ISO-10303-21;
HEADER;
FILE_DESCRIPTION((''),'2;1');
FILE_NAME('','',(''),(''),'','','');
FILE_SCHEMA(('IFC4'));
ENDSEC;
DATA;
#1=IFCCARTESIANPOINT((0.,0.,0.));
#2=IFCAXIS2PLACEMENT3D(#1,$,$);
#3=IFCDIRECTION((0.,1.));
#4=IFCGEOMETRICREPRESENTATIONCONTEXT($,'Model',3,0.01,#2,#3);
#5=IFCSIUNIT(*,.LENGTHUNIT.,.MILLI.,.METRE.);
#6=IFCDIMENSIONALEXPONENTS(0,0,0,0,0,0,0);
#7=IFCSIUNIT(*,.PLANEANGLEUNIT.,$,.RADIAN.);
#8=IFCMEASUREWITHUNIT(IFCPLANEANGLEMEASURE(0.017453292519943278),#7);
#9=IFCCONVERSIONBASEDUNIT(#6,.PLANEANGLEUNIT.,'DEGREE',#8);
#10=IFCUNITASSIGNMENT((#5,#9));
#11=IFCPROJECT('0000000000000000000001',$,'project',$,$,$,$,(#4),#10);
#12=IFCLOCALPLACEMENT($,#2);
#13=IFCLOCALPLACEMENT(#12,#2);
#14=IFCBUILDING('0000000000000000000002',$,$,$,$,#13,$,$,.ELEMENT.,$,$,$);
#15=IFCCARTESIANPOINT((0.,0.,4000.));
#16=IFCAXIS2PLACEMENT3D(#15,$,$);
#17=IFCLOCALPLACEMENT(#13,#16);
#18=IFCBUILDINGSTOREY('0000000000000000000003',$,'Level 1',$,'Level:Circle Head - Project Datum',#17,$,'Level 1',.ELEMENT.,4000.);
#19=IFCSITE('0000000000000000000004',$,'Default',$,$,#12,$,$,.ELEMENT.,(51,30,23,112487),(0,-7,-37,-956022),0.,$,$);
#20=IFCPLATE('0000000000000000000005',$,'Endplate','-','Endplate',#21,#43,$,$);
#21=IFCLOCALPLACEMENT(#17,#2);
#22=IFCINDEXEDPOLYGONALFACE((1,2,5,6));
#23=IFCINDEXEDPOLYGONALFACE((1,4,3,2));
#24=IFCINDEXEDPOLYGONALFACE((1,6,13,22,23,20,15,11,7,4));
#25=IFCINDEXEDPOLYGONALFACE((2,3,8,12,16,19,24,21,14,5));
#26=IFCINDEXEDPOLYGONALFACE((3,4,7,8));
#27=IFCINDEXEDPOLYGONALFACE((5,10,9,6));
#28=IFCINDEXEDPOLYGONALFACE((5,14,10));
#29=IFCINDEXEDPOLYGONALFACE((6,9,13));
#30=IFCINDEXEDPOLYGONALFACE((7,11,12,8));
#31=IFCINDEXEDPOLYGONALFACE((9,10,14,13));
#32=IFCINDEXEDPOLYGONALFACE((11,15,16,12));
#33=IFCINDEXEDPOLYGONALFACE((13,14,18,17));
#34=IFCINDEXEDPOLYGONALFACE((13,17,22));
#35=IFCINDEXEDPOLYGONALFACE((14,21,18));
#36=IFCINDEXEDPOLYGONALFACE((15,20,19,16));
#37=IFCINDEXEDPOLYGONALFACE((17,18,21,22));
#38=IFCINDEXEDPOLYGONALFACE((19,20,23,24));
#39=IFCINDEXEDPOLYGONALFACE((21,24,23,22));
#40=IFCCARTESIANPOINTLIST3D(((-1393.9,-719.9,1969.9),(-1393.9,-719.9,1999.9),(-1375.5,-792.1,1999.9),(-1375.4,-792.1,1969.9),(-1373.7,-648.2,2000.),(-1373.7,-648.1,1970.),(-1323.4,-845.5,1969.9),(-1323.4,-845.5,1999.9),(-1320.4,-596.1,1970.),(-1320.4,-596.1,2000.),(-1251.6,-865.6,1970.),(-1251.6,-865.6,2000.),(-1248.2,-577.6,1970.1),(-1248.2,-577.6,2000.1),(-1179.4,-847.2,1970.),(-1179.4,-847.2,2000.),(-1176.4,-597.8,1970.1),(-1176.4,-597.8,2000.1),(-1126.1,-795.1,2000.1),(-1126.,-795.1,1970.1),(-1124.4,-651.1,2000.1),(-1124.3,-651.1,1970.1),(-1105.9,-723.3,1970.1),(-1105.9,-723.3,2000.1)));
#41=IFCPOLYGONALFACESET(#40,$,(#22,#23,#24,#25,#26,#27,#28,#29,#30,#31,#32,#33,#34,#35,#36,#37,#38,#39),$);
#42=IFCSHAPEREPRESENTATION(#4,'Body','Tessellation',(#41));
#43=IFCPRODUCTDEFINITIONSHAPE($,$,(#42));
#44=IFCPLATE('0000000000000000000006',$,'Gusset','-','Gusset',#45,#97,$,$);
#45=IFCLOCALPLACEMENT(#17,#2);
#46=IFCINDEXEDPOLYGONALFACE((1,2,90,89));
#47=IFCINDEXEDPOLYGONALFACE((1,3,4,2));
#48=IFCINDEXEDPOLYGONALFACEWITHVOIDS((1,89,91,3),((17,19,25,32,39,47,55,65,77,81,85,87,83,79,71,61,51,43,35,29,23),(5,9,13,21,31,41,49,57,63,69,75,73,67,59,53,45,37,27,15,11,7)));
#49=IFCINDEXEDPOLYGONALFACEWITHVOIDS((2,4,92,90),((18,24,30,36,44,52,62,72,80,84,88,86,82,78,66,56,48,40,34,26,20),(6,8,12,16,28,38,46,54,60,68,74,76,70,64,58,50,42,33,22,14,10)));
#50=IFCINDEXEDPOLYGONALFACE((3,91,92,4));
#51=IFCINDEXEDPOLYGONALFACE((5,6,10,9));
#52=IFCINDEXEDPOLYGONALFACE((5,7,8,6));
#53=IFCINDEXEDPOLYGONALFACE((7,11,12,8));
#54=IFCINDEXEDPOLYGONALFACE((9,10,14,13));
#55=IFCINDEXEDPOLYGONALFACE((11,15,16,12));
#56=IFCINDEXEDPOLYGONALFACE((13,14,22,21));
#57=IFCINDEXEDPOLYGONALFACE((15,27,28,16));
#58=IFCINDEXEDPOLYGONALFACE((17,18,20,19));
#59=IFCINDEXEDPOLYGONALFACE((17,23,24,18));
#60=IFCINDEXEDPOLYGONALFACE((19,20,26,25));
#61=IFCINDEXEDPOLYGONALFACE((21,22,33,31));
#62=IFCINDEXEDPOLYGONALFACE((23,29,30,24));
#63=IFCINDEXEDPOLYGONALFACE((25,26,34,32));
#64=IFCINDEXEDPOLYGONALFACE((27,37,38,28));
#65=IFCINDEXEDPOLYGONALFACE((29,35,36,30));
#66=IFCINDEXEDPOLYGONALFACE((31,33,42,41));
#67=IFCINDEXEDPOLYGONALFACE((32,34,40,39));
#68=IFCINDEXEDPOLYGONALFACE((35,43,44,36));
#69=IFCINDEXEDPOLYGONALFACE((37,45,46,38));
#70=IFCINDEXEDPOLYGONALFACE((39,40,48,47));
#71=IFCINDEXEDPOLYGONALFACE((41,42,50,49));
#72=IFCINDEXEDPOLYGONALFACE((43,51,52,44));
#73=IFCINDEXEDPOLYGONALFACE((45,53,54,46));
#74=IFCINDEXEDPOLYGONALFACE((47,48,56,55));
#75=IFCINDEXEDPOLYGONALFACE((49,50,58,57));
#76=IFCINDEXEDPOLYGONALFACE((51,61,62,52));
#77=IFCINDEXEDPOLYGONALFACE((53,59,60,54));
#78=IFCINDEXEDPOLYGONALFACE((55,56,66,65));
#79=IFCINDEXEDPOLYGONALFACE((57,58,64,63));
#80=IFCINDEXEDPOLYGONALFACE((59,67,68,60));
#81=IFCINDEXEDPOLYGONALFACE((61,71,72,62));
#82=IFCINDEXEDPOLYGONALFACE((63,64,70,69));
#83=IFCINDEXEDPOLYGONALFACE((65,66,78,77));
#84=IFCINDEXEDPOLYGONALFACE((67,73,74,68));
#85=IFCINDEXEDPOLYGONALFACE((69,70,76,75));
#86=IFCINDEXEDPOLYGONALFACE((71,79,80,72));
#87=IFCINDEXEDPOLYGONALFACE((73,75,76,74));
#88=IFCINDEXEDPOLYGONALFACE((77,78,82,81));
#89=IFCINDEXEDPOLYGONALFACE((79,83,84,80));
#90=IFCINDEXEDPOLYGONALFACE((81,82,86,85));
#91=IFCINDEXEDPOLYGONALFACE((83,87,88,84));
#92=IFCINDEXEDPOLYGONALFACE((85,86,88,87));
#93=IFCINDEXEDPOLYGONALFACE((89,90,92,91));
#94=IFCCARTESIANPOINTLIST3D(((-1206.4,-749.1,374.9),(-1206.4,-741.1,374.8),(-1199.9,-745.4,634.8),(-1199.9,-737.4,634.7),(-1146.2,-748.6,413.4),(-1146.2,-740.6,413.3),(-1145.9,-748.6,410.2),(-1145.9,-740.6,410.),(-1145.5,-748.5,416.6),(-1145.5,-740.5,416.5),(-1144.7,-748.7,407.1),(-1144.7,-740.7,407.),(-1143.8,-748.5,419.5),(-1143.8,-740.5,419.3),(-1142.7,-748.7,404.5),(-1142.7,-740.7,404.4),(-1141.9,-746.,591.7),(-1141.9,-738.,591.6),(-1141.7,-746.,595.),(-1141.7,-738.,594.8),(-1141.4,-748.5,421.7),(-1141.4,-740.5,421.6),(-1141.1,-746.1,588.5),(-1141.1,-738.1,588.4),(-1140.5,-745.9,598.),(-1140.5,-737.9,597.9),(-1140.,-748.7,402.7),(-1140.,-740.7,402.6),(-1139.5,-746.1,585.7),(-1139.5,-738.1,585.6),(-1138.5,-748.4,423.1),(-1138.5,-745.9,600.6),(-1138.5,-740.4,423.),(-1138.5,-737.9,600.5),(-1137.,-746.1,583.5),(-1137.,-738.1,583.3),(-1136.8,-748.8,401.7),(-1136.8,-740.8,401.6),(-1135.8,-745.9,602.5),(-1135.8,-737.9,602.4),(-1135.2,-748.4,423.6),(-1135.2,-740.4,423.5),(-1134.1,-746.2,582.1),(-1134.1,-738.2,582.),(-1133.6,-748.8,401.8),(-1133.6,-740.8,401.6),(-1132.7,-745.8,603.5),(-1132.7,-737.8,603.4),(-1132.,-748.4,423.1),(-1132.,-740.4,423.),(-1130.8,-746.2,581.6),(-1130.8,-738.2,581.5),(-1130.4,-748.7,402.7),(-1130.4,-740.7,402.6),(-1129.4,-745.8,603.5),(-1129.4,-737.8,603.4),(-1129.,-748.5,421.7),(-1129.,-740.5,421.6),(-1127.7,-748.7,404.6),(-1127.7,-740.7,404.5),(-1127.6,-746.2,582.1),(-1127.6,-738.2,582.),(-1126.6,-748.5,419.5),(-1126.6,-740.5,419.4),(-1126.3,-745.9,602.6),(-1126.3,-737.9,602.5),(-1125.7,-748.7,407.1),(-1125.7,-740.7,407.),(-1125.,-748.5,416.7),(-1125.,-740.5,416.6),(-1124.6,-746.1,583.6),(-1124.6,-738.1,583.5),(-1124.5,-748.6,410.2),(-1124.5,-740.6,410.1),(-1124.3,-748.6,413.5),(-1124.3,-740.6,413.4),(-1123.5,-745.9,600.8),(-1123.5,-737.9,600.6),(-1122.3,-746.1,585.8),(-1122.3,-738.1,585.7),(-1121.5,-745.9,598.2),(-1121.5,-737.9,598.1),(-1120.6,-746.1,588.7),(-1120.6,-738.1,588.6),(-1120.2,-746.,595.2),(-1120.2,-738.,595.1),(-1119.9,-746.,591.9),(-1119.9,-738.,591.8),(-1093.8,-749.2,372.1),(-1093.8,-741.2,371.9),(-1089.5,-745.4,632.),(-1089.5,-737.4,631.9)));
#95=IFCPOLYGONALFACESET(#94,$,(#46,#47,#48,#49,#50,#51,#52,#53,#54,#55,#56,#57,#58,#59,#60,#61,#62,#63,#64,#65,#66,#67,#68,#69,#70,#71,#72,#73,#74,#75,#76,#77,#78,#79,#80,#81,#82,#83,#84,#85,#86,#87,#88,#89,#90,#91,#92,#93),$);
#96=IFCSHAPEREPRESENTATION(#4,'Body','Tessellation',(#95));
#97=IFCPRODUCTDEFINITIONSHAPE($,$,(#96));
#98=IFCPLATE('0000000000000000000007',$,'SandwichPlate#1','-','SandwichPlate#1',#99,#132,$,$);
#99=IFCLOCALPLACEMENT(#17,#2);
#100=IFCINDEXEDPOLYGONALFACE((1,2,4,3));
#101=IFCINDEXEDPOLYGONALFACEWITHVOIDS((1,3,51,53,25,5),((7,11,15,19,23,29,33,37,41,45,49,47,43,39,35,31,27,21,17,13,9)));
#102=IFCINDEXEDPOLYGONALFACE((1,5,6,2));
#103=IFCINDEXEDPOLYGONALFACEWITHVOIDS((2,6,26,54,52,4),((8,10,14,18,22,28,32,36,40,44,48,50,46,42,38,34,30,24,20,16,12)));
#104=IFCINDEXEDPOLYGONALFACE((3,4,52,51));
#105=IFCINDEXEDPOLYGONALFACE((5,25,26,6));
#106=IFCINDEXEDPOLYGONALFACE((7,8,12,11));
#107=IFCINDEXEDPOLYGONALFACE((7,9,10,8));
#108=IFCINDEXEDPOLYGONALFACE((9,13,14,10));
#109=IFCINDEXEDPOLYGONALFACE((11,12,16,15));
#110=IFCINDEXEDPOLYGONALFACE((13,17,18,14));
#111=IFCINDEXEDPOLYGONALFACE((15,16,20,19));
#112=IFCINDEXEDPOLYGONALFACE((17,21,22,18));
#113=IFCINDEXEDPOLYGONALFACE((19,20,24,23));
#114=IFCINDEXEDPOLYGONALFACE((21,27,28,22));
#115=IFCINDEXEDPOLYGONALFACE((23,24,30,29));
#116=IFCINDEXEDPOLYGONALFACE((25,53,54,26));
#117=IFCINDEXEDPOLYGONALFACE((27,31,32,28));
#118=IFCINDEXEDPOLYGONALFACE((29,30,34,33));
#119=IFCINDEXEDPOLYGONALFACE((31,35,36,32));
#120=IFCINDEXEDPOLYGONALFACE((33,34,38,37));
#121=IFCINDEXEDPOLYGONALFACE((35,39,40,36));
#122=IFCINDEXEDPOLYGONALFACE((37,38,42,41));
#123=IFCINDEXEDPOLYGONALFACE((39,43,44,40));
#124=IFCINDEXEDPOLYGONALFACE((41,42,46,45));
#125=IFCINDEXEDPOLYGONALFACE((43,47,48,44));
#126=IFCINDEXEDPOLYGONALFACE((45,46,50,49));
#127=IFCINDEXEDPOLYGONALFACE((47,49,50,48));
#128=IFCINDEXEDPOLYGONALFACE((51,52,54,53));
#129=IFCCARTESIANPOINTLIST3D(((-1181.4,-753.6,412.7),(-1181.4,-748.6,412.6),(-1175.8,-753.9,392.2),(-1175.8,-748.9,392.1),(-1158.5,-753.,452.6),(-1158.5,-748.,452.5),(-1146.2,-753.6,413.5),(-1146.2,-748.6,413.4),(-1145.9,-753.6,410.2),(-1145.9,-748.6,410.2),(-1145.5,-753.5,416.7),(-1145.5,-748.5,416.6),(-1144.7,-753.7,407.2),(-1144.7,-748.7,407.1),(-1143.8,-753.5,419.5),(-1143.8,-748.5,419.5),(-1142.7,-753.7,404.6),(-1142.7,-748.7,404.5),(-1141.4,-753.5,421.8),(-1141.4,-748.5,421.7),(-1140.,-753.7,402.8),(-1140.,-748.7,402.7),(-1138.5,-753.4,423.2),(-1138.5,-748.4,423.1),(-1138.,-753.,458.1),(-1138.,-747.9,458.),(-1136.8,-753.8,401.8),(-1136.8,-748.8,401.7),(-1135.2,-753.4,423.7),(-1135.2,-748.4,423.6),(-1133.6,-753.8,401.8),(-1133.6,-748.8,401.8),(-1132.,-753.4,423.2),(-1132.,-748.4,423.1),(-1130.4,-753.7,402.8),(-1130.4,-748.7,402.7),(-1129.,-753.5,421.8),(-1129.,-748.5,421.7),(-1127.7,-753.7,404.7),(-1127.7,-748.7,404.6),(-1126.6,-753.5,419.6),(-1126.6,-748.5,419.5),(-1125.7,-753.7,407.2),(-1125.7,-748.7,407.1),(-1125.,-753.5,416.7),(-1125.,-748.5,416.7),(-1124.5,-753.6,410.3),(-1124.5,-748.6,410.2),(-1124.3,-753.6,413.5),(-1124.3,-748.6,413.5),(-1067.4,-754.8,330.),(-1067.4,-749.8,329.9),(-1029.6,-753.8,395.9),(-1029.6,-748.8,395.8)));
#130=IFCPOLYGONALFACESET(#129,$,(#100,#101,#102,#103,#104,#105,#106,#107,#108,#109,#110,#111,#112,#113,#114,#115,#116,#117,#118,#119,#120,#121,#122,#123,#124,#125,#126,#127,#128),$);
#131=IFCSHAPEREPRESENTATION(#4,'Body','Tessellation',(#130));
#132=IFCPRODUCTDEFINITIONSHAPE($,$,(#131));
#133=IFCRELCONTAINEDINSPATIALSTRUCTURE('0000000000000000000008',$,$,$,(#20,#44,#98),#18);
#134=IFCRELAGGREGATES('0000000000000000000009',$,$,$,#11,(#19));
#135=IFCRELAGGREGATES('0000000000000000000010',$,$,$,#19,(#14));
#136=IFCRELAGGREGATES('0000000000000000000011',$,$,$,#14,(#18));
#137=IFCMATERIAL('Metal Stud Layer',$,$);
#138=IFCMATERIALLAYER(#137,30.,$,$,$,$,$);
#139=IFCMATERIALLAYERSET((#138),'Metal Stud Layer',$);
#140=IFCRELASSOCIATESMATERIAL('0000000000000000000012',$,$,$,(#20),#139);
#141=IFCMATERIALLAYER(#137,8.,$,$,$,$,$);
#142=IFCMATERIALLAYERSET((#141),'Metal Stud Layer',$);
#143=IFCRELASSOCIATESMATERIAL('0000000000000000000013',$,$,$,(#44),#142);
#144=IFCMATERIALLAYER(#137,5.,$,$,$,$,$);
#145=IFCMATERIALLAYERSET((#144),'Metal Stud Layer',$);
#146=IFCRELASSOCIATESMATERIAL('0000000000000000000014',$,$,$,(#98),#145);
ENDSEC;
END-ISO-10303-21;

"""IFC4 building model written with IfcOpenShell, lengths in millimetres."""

from ifc_helpers import new_model, entity, si_unit, converted_unit, point, direction, frame, frame_2d, origin, origin_with_axes, origin_2d_with_axis, place, context, project, spatial, polyline, circle_curve, line_curve, trimmed, segment, composite_curve, circle, outline, extrude, material, layer, layer_set, element, save


model = new_model("IFC4")

# Units and contexts
model_context = context("Model", 3, precision=0.01, world=origin(), true_north=direction((0.0, 1.0)))
ifc_project = project(units=[si_unit("LENGTHUNIT", "METRE", prefix="MILLI"), converted_unit("PLANEANGLEUNIT", "DEGREE", entity("IfcPlaneAngleMeasure", 0.017453292519943278), si_unit("PLANEANGLEUNIT", "RADIAN"), dimensions=[0, 0, 0, 0, 0, 0, 0])], contexts=[model_context])

# Site, building, storey
site_placement = place(None, origin())
site = spatial("IfcSite", under=ifc_project, at=site_placement, Name="Default", CompositionType="ELEMENT", RefLatitude=(51, 30, 23, 112487), RefLongitude=(0, -7, -37, -956022), RefElevation=0.0)
building_placement = place(site_placement, origin())
building = spatial("IfcBuilding", under=site, at=building_placement, CompositionType="ELEMENT")
storey_placement = place(building_placement, frame((0.0, 0.0, 4000.0)))
storey = spatial("IfcBuildingStorey", under=building, at=storey_placement, Name="Level 1", ObjectType="Level:Circle Head - Project Datum", LongName="Level 1", CompositionType="ELEMENT", Elevation=4000.0)

# Plates, openings
ifc_material_1 = material(Name="Metal Stud Layer")
ifc_layer_1 = layer(ifc_material_1, 30.0)
ifc_layer_set_1 = layer_set([ifc_layer_1], Name="Metal Stud Layer")
plate_1_placement = place(storey_placement, frame((-1179.4, -847.2, 1970.0), z_axis=(-0.000702, -0.000406, 1.0), x_axis=(0.871905, 0.489674, 0.000811)))
plate_1 = element("IfcPlate", 1, at=plate_1_placement, inside=storey, material=ifc_layer_set_1, Name="Endplate", Description="-", ObjectType="Endplate", context=model_context, shape_type="SweptSolid", body=[
    extrude(outline(polyline([(144.0, 0.0), (144.0, 288.0), (-144.0, 288.0), (-144.0, 0.0), (144.0, 0.0)])), origin_with_axes(), (0.0, 0.0, 1.0), 30.0),
])
opening_1_placement = place(plate_1_placement, frame((0.0, 0.0, 0.0), z_axis=(0.0, 0.0, 1.0), x_axis=(1.0, 0.0, 0.0)))
element("IfcOpeningElement", 2, at=opening_1_placement, cuts=plate_1, ObjectType="Opening", context=model_context, shape_type="SweptSolid", body=[
    extrude(outline(composite_curve([segment(trimmed(line_curve((144.0, 0.0), (0.0, 1.0), 144.0), [point((144.0, 0.0))], [point((144.0, 144.0))], True, "CARTESIAN"), True, "CONTINUOUS"), segment(trimmed(circle_curve(frame_2d((0.0, 144.0), x_axis=(-1.0, 0.0)), 144.0), [point((144.0, 144.0))], [point((0.0, 0.0))], False, "CARTESIAN"), True, "CONTINUOUS"), segment(trimmed(line_curve((0.0, 0.0), (1.0, 0.0), 144.0), [point((0.0, 0.0))], [point((144.0, 0.0))], True, "CARTESIAN"), True, "CONTINUOUS")], self_intersect="UNKNOWN")), origin(), (0.0, 0.0, 1.0), 30.0),
])
opening_2_placement = place(plate_1_placement, frame((0.0, 0.0, 0.0), z_axis=(0.0, 0.0, 1.0), x_axis=(1.0, 0.0, 0.0)))
element("IfcOpeningElement", 3, at=opening_2_placement, cuts=plate_1, ObjectType="Opening", context=model_context, shape_type="SweptSolid", body=[
    extrude(outline(composite_curve([segment(trimmed(line_curve((144.0, 288.0), (-1.0, 0.0), 144.0), [point((144.0, 288.0))], [point((0.0, 288.0))], True, "CARTESIAN"), True, "CONTINUOUS"), segment(trimmed(circle_curve(frame_2d((0.0, 144.0), x_axis=(-1.0, 0.0)), 144.0), [point((0.0, 288.0))], [point((144.0, 144.0))], False, "CARTESIAN"), True, "CONTINUOUS"), segment(trimmed(line_curve((144.0, 144.0), (0.0, 1.0), 144.0), [point((144.0, 144.0))], [point((144.0, 288.0))], True, "CARTESIAN"), True, "CONTINUOUS")], self_intersect="UNKNOWN")), origin(), (0.0, 0.0, 1.0), 30.0),
])
opening_3_placement = place(plate_1_placement, frame((0.0, 0.0, 0.0), z_axis=(0.0, 0.0, 1.0), x_axis=(1.0, 0.0, 0.0)))
element("IfcOpeningElement", 4, at=opening_3_placement, cuts=plate_1, ObjectType="Opening", context=model_context, shape_type="SweptSolid", body=[
    extrude(outline(composite_curve([segment(trimmed(line_curve((-144.0, 288.0), (0.0, -1.0), 144.0), [point((-144.0, 288.0))], [point((-144.0, 144.0))], True, "CARTESIAN"), True, "CONTINUOUS"), segment(trimmed(circle_curve(frame_2d((0.0, 144.0), x_axis=(-1.0, 0.0)), 144.0), [point((-144.0, 144.0))], [point((0.0, 288.0))], False, "CARTESIAN"), True, "CONTINUOUS"), segment(trimmed(line_curve((0.0, 288.0), (-1.0, 0.0), 144.0), [point((0.0, 288.0))], [point((-144.0, 288.0))], True, "CARTESIAN"), True, "CONTINUOUS")], self_intersect="UNKNOWN")), origin(), (0.0, 0.0, 1.0), 30.0),
])
opening_4_placement = place(plate_1_placement, frame((0.0, 0.0, 0.0), z_axis=(0.0, 0.0, 1.0), x_axis=(1.0, 0.0, 0.0)))
element("IfcOpeningElement", 5, at=opening_4_placement, cuts=plate_1, ObjectType="Opening", context=model_context, shape_type="SweptSolid", body=[
    extrude(outline(composite_curve([segment(trimmed(line_curve((-144.0, 0.0), (1.0, 0.0), 144.0), [point((-144.0, 0.0))], [point((0.0, 0.0))], True, "CARTESIAN"), True, "CONTINUOUS"), segment(trimmed(circle_curve(frame_2d((0.0, 144.0), x_axis=(-1.0, 0.0)), 144.0), [point((0.0, 0.0))], [point((-144.0, 144.0))], False, "CARTESIAN"), True, "CONTINUOUS"), segment(trimmed(line_curve((-144.0, 144.0), (0.0, -1.0), 144.0), [point((-144.0, 144.0))], [point((-144.0, 0.0))], True, "CARTESIAN"), True, "CONTINUOUS")], self_intersect="UNKNOWN")), origin(), (0.0, 0.0, 1.0), 30.0),
])
ifc_layer_2 = layer(ifc_material_1, 8.0)
ifc_layer_set_2 = layer_set([ifc_layer_2], Name="Metal Stud Layer")
plate_2_placement = place(storey_placement, frame((-1197.6, -737.4, 634.9), z_axis=(0.0, -0.999896, 0.014432), x_axis=(-0.02499, -0.014428, -0.999584)))
plate_2 = element("IfcPlate", 6, at=plate_2_placement, inside=storey, material=ifc_layer_set_2, Name="Gusset", Description="-", ObjectType="Gusset", context=model_context, shape_type="SweptSolid", body=[
    extrude(outline(polyline([(0.3, -2.3), (260.3, -2.3), (260.3, 110.4), (0.3, 108.2), (0.3, -2.3)])), origin_with_axes(), (0.0, 0.0, 1.0), 8.0),
])
opening_5_placement = place(plate_2_placement, frame((220.8, 68.0, 8.5), z_axis=(0.0, 0.0, -1.0), x_axis=(0.476138, 0.879371, 0.0)))
element("IfcOpeningElement", 7, at=opening_5_placement, cuts=plate_2, ObjectType="Opening", context=model_context, shape_type="SweptSolid", body=[
    extrude(circle(Radius=11.0, at=origin_2d_with_axis()), origin(), (0.0, 0.0, 1.0), 9.0),
])
opening_6_placement = place(plate_2_placement, frame((40.7, 67.8, 8.5), z_axis=(0.0, 0.0, -1.0), x_axis=(-0.530264, 0.847833, 0.0)))
element("IfcOpeningElement", 8, at=opening_6_placement, cuts=plate_2, ObjectType="Opening", context=model_context, shape_type="SweptSolid", body=[
    extrude(circle(Radius=11.0, at=origin_2d_with_axis()), origin(), (0.0, 0.0, 1.0), 9.0),
])
ifc_layer_3 = layer(ifc_material_1, 5.0)
ifc_layer_set_3 = layer_set([ifc_layer_3], Name="Metal Stud Layer")
plate_3_placement = place(storey_placement, frame((-1188.8, -753.8, 399.7), z_axis=(0.0, 0.999896, -0.014432), x_axis=(0.497964, 0.012516, 0.867107)))
plate_3 = element("IfcPlate", 9, at=plate_3_placement, inside=storey, material=ifc_layer_set_3, Name="SandwichPlate#1", Description="-", ObjectType="SandwichPlate#1", context=model_context, shape_type="SweptSolid", body=[
    extrude(outline(polyline([(0.0, 0.0), (76.0, 0.0), (76.0, 140.0), (0.0, 140.0), (0.0, 0.0)])), origin_with_axes(), (0.0, 0.0, 1.0), 5.0),
])
opening_7_placement = place(plate_3_placement, frame((0.0, 0.0, 0.0), z_axis=(0.0, 0.0, 1.0), x_axis=(1.0, 0.0, 0.0)))
element("IfcOpeningElement", 10, at=opening_7_placement, cuts=plate_3, ObjectType="Opening", context=model_context, shape_type="SweptSolid", body=[
    extrude(outline(polyline([(0.0, 0.0), (15.0, 0.0), (0.0, 15.0), (0.0, 0.0)])), origin(), (0.0, 0.0, 1.0), 5.0),
])
opening_8_placement = place(plate_3_placement, frame((0.0, 0.0, 0.0), z_axis=(0.0, 0.0, 1.0), x_axis=(1.0, 0.0, 0.0)))
element("IfcOpeningElement", 11, at=opening_8_placement, cuts=plate_3, ObjectType="Opening", context=model_context, shape_type="SweptSolid", body=[
    extrude(outline(polyline([(76.0, 0.0), (76.0, 15.0), (61.0, 0.0), (76.0, 0.0)])), origin(), (0.0, 0.0, 1.0), 5.0),
])
opening_9_placement = place(plate_3_placement, frame((38.0, 40.0, -0.5), z_axis=(0.0, 0.0, 1.0), x_axis=(0.0, 1.0, 0.0)))
element("IfcOpeningElement", 12, at=opening_9_placement, cuts=plate_3, ObjectType="Opening", context=model_context, shape_type="SweptSolid", body=[
    extrude(circle(Radius=11.0, at=origin_2d_with_axis()), origin(), (0.0, 0.0, 1.0), 6.0),
])

save(model, "model.ifc")
